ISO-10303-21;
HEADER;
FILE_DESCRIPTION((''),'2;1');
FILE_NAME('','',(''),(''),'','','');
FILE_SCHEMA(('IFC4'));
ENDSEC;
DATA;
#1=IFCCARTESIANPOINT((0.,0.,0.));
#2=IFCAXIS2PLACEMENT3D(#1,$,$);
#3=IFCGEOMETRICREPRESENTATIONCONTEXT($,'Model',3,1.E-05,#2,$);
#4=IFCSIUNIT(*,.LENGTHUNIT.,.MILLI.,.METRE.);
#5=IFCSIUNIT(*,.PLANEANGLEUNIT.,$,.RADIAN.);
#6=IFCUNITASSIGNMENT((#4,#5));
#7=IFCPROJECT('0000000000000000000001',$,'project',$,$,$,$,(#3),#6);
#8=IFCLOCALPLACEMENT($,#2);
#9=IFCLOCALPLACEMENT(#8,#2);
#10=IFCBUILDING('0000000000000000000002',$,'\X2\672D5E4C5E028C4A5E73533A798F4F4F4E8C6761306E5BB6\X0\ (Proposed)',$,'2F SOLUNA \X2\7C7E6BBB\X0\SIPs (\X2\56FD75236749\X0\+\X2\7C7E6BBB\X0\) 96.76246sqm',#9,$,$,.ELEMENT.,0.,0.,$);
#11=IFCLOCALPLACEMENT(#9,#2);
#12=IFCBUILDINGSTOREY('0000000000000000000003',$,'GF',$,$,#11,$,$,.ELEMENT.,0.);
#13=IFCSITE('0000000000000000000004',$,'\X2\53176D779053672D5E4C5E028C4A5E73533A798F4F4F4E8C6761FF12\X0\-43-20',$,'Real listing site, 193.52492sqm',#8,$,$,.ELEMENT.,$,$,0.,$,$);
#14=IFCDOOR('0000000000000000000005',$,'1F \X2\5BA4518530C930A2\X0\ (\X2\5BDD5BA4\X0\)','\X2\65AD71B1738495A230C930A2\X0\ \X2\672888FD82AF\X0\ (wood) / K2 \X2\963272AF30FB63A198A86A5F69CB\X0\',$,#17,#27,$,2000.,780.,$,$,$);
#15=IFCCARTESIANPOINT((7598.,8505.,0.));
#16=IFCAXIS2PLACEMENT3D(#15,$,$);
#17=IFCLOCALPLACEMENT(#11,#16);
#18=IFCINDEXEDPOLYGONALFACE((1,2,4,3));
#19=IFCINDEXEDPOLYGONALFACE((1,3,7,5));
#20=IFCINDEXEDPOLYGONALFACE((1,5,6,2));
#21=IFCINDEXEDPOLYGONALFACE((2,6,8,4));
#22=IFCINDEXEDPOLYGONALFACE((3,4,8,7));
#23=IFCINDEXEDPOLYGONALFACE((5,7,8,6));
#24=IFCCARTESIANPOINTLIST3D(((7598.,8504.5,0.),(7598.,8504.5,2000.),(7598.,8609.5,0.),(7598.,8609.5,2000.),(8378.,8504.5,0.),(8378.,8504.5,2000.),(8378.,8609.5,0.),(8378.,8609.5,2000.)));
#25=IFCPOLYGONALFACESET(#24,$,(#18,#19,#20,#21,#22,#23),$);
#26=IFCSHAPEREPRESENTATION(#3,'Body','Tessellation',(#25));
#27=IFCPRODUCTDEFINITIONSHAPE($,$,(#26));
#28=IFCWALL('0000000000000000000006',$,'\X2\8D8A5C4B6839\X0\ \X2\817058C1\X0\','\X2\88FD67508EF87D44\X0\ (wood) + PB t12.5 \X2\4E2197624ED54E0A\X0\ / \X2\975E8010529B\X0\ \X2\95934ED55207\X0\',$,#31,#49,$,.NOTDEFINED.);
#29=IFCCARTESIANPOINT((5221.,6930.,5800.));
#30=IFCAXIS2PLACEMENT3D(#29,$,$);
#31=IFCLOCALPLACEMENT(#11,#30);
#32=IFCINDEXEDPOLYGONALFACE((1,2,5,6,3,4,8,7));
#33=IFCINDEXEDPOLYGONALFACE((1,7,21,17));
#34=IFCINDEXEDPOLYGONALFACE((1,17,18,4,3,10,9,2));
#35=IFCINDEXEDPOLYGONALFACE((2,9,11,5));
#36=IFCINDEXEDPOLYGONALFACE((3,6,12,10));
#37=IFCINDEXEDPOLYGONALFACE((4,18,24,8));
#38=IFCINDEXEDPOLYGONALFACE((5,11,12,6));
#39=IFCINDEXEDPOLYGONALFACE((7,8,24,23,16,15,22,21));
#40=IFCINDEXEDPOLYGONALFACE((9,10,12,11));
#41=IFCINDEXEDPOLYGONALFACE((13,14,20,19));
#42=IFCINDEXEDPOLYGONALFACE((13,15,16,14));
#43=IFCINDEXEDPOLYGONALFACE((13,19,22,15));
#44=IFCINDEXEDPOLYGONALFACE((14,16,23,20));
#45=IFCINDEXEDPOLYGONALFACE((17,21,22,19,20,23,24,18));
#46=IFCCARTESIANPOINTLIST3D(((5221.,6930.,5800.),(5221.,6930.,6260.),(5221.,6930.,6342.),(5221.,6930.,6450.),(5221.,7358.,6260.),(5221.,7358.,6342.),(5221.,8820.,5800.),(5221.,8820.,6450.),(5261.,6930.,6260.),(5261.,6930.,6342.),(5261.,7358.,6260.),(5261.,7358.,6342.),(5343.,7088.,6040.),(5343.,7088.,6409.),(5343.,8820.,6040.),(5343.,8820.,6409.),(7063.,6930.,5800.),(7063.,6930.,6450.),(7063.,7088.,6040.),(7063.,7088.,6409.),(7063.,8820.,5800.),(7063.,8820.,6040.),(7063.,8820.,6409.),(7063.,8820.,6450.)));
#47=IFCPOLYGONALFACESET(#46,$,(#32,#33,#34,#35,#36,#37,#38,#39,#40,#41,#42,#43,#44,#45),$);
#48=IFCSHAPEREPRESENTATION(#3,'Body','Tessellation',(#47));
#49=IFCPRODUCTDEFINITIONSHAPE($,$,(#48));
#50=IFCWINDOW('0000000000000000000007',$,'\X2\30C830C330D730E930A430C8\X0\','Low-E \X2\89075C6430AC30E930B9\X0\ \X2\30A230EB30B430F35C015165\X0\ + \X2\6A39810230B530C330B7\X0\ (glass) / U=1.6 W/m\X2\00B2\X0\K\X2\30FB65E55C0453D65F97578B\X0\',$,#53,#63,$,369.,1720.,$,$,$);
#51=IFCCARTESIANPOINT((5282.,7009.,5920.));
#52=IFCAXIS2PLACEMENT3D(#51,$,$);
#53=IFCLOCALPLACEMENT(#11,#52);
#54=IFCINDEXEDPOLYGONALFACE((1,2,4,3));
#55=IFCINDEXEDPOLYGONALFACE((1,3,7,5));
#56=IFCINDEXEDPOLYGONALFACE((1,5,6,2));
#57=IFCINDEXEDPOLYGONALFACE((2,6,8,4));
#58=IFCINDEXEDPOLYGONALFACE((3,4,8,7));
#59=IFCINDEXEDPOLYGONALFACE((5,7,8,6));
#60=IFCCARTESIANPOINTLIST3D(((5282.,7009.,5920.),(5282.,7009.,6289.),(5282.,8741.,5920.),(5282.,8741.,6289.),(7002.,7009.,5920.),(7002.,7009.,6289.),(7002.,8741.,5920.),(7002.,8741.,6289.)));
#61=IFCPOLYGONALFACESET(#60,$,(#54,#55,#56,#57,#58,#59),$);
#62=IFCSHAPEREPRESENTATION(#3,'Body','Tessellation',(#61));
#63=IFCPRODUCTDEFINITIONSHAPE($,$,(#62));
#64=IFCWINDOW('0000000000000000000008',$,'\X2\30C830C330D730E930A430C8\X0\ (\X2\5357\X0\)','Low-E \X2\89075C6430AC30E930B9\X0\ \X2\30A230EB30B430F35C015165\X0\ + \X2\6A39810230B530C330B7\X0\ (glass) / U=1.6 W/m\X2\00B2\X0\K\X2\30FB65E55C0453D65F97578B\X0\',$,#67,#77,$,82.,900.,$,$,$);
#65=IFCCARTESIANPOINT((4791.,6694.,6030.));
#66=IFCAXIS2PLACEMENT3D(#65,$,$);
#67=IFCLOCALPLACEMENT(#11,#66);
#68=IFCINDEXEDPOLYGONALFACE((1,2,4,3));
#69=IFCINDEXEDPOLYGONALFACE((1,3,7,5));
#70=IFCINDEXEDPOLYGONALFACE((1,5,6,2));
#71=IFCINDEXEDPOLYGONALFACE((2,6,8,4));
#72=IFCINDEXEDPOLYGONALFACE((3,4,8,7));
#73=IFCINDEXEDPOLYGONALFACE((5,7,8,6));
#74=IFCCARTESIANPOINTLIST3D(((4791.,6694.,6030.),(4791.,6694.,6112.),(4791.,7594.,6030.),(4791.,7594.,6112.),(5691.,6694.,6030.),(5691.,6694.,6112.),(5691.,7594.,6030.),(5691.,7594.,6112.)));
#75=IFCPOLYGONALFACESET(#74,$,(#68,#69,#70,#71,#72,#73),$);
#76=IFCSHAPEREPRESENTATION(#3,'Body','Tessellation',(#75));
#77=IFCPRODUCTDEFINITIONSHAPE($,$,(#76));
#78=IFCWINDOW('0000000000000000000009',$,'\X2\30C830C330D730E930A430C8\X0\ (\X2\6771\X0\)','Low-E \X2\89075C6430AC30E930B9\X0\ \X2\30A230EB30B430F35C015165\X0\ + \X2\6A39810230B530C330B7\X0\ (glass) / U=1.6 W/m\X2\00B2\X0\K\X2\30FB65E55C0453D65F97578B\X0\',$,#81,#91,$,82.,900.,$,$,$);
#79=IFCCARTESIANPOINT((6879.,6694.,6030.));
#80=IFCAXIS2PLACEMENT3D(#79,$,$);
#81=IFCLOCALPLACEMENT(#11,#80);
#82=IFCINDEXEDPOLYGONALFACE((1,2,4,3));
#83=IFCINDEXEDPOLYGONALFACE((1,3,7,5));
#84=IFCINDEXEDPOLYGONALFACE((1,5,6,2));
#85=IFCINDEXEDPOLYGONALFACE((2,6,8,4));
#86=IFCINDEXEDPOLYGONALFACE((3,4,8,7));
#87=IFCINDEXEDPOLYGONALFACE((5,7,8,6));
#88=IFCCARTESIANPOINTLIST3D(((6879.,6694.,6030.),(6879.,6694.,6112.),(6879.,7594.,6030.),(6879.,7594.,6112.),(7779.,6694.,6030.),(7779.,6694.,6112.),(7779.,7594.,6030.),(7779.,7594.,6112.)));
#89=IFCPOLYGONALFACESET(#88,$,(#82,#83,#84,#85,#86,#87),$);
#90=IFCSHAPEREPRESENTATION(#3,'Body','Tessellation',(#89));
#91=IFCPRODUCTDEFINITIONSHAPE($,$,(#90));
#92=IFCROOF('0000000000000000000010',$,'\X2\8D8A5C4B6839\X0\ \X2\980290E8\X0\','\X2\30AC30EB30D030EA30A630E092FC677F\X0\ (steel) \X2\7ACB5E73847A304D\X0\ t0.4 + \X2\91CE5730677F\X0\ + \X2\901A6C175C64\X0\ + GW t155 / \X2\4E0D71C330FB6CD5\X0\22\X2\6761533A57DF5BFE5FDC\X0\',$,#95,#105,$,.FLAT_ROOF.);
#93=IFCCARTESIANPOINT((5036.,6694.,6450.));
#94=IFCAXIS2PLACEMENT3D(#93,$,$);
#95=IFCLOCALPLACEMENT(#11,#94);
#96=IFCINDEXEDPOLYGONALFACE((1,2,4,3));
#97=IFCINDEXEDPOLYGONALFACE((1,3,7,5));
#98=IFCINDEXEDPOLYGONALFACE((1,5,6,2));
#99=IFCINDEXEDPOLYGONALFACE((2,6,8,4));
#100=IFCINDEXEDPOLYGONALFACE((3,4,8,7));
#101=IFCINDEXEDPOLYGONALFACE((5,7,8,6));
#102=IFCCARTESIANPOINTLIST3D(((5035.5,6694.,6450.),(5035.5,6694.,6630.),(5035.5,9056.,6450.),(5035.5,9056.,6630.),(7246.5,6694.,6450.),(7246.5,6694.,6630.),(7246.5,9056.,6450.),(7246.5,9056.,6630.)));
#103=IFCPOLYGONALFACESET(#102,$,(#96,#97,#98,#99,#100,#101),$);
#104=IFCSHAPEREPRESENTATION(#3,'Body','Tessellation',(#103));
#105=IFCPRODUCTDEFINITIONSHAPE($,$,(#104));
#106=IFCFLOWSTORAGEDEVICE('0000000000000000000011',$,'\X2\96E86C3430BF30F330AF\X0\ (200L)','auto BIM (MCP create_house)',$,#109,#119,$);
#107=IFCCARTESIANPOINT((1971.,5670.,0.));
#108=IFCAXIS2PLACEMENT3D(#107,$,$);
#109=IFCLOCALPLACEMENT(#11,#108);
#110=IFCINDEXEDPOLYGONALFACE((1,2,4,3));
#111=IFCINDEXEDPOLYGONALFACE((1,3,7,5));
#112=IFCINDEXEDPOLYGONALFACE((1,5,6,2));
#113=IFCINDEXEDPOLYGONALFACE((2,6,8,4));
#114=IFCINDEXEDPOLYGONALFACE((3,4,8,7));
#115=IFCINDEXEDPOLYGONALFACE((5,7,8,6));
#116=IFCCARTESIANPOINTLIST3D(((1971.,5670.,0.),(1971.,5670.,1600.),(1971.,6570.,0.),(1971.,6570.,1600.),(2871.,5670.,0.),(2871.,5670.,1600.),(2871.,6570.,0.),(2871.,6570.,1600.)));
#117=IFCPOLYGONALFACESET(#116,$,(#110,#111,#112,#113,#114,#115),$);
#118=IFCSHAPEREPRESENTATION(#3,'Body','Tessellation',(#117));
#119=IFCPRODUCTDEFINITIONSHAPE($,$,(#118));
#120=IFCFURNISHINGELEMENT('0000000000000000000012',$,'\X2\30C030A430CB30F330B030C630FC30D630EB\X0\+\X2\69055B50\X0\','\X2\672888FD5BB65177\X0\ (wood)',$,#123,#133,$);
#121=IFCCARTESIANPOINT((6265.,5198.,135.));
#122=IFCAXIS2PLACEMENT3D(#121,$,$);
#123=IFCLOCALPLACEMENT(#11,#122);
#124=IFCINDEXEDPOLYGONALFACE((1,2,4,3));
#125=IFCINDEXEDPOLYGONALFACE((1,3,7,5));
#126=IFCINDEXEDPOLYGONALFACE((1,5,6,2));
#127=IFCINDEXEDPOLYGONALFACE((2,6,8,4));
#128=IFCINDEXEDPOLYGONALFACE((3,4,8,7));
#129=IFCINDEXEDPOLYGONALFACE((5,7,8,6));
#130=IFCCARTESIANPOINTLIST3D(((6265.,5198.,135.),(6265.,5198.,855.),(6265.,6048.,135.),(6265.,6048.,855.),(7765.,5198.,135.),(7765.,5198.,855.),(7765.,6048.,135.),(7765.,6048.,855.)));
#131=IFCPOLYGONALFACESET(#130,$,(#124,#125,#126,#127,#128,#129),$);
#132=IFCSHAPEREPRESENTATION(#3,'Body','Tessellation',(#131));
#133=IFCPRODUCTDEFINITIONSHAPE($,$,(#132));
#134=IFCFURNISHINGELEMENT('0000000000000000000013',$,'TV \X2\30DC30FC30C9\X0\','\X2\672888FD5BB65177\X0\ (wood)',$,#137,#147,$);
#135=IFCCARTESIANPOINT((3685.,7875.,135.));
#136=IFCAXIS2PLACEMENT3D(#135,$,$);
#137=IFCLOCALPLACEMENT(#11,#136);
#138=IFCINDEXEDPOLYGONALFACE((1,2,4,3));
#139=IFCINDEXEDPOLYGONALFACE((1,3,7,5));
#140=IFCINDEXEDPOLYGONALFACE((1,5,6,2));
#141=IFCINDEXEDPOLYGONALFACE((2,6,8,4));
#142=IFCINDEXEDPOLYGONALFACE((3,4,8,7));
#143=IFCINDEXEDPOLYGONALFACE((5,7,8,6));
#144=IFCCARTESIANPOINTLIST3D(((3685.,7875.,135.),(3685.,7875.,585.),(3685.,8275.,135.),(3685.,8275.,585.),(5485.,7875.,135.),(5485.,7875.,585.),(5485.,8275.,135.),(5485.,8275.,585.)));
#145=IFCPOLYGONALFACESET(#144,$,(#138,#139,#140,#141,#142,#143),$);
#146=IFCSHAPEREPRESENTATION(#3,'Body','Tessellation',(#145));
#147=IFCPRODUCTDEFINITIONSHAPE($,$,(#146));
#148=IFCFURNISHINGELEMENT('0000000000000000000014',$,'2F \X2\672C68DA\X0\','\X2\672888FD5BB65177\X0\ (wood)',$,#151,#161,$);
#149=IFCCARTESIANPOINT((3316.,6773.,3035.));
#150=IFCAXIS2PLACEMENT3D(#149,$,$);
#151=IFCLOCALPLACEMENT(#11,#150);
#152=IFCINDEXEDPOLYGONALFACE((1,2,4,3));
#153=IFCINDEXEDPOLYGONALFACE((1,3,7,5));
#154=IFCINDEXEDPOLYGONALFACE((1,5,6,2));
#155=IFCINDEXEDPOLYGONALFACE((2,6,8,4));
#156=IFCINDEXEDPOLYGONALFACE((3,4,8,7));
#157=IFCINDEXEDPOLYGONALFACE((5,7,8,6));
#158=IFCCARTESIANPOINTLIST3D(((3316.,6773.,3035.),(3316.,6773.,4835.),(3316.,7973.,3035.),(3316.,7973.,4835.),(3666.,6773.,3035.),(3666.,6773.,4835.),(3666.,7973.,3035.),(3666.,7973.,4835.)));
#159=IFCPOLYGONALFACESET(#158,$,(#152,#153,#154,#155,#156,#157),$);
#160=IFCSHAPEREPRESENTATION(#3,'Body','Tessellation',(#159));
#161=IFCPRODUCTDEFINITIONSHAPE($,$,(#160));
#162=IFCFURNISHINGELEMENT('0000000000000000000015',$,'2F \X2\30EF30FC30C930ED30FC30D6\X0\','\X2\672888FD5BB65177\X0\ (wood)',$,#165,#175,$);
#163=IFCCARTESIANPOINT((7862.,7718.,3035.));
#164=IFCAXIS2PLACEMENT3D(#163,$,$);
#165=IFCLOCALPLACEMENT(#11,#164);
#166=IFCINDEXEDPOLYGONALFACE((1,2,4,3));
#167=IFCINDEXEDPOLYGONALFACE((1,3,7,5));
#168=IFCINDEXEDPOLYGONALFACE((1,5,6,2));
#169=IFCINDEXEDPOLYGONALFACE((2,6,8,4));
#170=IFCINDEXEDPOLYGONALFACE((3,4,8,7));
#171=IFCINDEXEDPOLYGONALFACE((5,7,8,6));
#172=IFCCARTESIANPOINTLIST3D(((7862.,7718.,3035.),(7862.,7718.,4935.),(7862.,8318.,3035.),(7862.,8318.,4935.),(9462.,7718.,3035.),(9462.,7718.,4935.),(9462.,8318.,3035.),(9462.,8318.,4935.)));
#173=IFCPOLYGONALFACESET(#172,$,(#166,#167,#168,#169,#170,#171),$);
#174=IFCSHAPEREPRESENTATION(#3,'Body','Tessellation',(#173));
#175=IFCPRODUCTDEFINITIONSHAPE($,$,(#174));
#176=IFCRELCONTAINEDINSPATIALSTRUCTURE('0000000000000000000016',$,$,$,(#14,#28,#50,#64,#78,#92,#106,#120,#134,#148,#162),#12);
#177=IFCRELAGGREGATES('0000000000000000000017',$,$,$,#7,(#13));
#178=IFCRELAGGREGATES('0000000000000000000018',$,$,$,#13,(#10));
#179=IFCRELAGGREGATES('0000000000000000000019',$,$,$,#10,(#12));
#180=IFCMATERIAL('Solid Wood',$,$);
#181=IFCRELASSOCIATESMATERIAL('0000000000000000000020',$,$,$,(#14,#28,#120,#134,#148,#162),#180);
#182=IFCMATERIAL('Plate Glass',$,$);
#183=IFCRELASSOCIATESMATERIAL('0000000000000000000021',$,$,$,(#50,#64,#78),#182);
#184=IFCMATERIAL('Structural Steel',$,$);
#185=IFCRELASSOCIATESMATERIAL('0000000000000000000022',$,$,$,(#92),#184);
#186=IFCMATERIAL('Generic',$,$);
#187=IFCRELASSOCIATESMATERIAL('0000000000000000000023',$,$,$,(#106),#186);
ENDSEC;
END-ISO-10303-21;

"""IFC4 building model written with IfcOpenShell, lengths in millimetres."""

from ifc_helpers import new_model, si_unit, frame, frame_2d, origin, place, context, project, spatial, rectangle, extrude, material, element, fill, save


model = new_model("IFC4")

# Units and contexts
model_context = context("Model", 3, precision=1e-05, world=origin())
ifc_project = project(units=[si_unit("LENGTHUNIT", "METRE", prefix="MILLI"), si_unit("PLANEANGLEUNIT", "RADIAN")], contexts=[model_context])

# Site, building, storey
site_placement = place(None, origin())
site = spatial("IfcSite", under=ifc_project, at=site_placement, Name="北海道札幌市豊平区福住二条２-43-20", ObjectType="Real listing site, 193.52492sqm", CompositionType="ELEMENT", RefElevation=0.0)
building_placement = place(site_placement, origin())
building = spatial("IfcBuilding", under=site, at=building_placement, Name="札幌市豊平区福住二条の家 (Proposed)", ObjectType="2F SOLUNA 籾殻SIPs (国産杉+籾殻) 96.76246sqm", CompositionType="ELEMENT", ElevationOfRefHeight=0.0, ElevationOfTerrain=0.0)
storey_placement = place(building_placement, origin())
storey = spatial("IfcBuildingStorey", under=building, at=storey_placement, Name="GF", CompositionType="ELEMENT", Elevation=0.0)

# Shared definitions
ifc_material_1 = material(Name="Solid Wood")

# Door
door_placement = place(storey_placement, frame((7598.0, 8505.0, 0.0)))
element("IfcDoor", 1, at=door_placement, inside=storey, material=ifc_material_1, Name="1F 室内ドア (寝室)", Description="断熱玄関ドア 木製芯 (wood) / K2 防犯・採風機構", OverallHeight=2000.0, OverallWidth=780.0, context=model_context, shape_type="SweptSolid", body=[
    extrude(rectangle(XDim=780.0, YDim=105.0, at=frame_2d((390.0, 52.0))), frame((7598.0, 8505.0, 0.0)), (0.0, 0.0, 1.0), 2000.0),
])

# Wall, openings, windows
wall_1_placement = place(storey_placement, frame((5221.0, 6930.0, 5800.0)))
wall_1 = element("IfcWall", 2, at=wall_1_placement, inside=storey, material=ifc_material_1, Name="越屋根 腰壁", Description="製材軸組 (wood) + PB t12.5 両面仕上 / 非耐力 間仕切", PredefinedType="NOTDEFINED", context=model_context, shape_type="SweptSolid", body=[
    extrude(rectangle(XDim=1842.0, YDim=1890.0, at=frame_2d((921.0, 945.0))), frame((5221.0, 6930.0, 5800.0)), (0.0, 0.0, 1.0), 650.0),
])
opening_1_placement = place(storey_placement, frame((5282.0, 7009.0, 5920.0)))
opening_1 = element("IfcOpeningElement", 3, at=opening_1_placement, cuts=wall_1, PredefinedType="NOTDEFINED", context=model_context, shape_type="SweptSolid", body=[
    extrude(rectangle(XDim=1720.0, YDim=1732.0, at=frame_2d((860.0, 866.0))), frame((5282.0, 7009.0, 5920.0)), (0.0, 0.0, 1.0), 369.0),
])
opening_2_placement = place(storey_placement, frame((4791.0, 6694.0, 6030.0)))
opening_2 = element("IfcOpeningElement", 4, at=opening_2_placement, cuts=wall_1, PredefinedType="NOTDEFINED", context=model_context, shape_type="SweptSolid", body=[
    extrude(rectangle(XDim=900.0, YDim=900.0, at=frame_2d((450.0, 450.0))), frame((4791.0, 6694.0, 6030.0)), (0.0, 0.0, 1.0), 82.0),
])
opening_3_placement = place(storey_placement, frame((6879.0, 6694.0, 6030.0)))
opening_3 = element("IfcOpeningElement", 5, at=opening_3_placement, cuts=wall_1, PredefinedType="NOTDEFINED", context=model_context, shape_type="SweptSolid", body=[
    extrude(rectangle(XDim=900.0, YDim=900.0, at=frame_2d((450.0, 450.0))), frame((6879.0, 6694.0, 6030.0)), (0.0, 0.0, 1.0), 82.0),
])
ifc_material_2 = material(Name="Plate Glass")
window_1_placement = place(storey_placement, frame((5282.0, 7009.0, 5920.0)))
window_1 = element("IfcWindow", 6, at=window_1_placement, inside=storey, material=ifc_material_2, Name="トップライト", Description="Low-E 複層ガラス アルゴン封入 + 樹脂サッシ (glass) / U=1.6 W/m²K・日射取得型", OverallHeight=369.0, OverallWidth=1720.0, context=model_context, shape_type="SweptSolid", body=[
    extrude(rectangle(XDim=1720.0, YDim=1732.0, at=frame_2d((860.0, 866.0))), frame((5282.0, 7009.0, 5920.0)), (0.0, 0.0, 1.0), 369.0),
])
fill(opening_1, window_1)
window_2_placement = place(storey_placement, frame((4791.0, 6694.0, 6030.0)))
window_2 = element("IfcWindow", 7, at=window_2_placement, inside=storey, material=ifc_material_2, Name="トップライト (南)", Description="Low-E 複層ガラス アルゴン封入 + 樹脂サッシ (glass) / U=1.6 W/m²K・日射取得型", OverallHeight=82.0, OverallWidth=900.0, context=model_context, shape_type="SweptSolid", body=[
    extrude(rectangle(XDim=900.0, YDim=900.0, at=frame_2d((450.0, 450.0))), frame((4791.0, 6694.0, 6030.0)), (0.0, 0.0, 1.0), 82.0),
])
fill(opening_2, window_2)
window_3_placement = place(storey_placement, frame((6879.0, 6694.0, 6030.0)))
window_3 = element("IfcWindow", 8, at=window_3_placement, inside=storey, material=ifc_material_2, Name="トップライト (東)", Description="Low-E 複層ガラス アルゴン封入 + 樹脂サッシ (glass) / U=1.6 W/m²K・日射取得型", OverallHeight=82.0, OverallWidth=900.0, context=model_context, shape_type="SweptSolid", body=[
    extrude(rectangle(XDim=900.0, YDim=900.0, at=frame_2d((450.0, 450.0))), frame((6879.0, 6694.0, 6030.0)), (0.0, 0.0, 1.0), 82.0),
])
fill(opening_3, window_3)

# Roof
ifc_material_3 = material(Name="Structural Steel")
roof_placement = place(storey_placement, frame((5036.0, 6694.0, 6450.0)))
element("IfcRoof", 9, at=roof_placement, inside=storey, material=ifc_material_3, Name="越屋根 頂部", Description="ガルバリウム鋼板 (steel) 立平葺き t0.4 + 野地板 + 通気層 + GW t155 / 不燃・法22条区域対応", PredefinedType="FLAT_ROOF", context=model_context, shape_type="SweptSolid", body=[
    extrude(rectangle(XDim=2211.0, YDim=2362.0, at=frame_2d((1105.0, 1181.0))), frame((5036.0, 6694.0, 6450.0)), (0.0, 0.0, 1.0), 180.0),
])

# Flow storage device
ifc_material_4 = material(Name="Generic")
flow_storage_device_placement = place(storey_placement, frame((1971.0, 5670.0, 0.0)))
element("IfcFlowStorageDevice", 10, at=flow_storage_device_placement, inside=storey, material=ifc_material_4, Name="雨水タンク (200L)", Description="auto BIM (MCP create_house)", context=model_context, shape_type="SweptSolid", body=[
    extrude(rectangle(XDim=900.0, YDim=900.0, at=frame_2d((450.0, 450.0))), frame((1971.0, 5670.0, 0.0)), (0.0, 0.0, 1.0), 1600.0),
])

# Furnishing elements
furnishing_1_placement = place(storey_placement, frame((6265.0, 5198.0, 135.0)))
element("IfcFurnishingElement", 11, at=furnishing_1_placement, inside=storey, material=ifc_material_1, Name="ダイニングテーブル+椅子", Description="木製家具 (wood)", context=model_context, shape_type="SweptSolid", body=[
    extrude(rectangle(XDim=1500.0, YDim=850.0, at=frame_2d((750.0, 425.0))), frame((6265.0, 5198.0, 135.0)), (0.0, 0.0, 1.0), 720.0),
])
furnishing_2_placement = place(storey_placement, frame((3685.0, 7875.0, 135.0)))
element("IfcFurnishingElement", 12, at=furnishing_2_placement, inside=storey, material=ifc_material_1, Name="TV ボード", Description="木製家具 (wood)", context=model_context, shape_type="SweptSolid", body=[
    extrude(rectangle(XDim=1800.0, YDim=400.0, at=frame_2d((900.0, 200.0))), frame((3685.0, 7875.0, 135.0)), (0.0, 0.0, 1.0), 450.0),
])
furnishing_3_placement = place(storey_placement, frame((3316.0, 6773.0, 3035.0)))
element("IfcFurnishingElement", 13, at=furnishing_3_placement, inside=storey, material=ifc_material_1, Name="2F 本棚", Description="木製家具 (wood)", context=model_context, shape_type="SweptSolid", body=[
    extrude(rectangle(XDim=350.0, YDim=1200.0, at=frame_2d((175.0, 600.0))), frame((3316.0, 6773.0, 3035.0)), (0.0, 0.0, 1.0), 1800.0),
])
furnishing_4_placement = place(storey_placement, frame((7862.0, 7718.0, 3035.0)))
element("IfcFurnishingElement", 14, at=furnishing_4_placement, inside=storey, material=ifc_material_1, Name="2F ワードローブ", Description="木製家具 (wood)", context=model_context, shape_type="SweptSolid", body=[
    extrude(rectangle(XDim=1600.0, YDim=600.0, at=frame_2d((800.0, 300.0))), frame((7862.0, 7718.0, 3035.0)), (0.0, 0.0, 1.0), 1900.0),
])

save(model, "model.ifc")
